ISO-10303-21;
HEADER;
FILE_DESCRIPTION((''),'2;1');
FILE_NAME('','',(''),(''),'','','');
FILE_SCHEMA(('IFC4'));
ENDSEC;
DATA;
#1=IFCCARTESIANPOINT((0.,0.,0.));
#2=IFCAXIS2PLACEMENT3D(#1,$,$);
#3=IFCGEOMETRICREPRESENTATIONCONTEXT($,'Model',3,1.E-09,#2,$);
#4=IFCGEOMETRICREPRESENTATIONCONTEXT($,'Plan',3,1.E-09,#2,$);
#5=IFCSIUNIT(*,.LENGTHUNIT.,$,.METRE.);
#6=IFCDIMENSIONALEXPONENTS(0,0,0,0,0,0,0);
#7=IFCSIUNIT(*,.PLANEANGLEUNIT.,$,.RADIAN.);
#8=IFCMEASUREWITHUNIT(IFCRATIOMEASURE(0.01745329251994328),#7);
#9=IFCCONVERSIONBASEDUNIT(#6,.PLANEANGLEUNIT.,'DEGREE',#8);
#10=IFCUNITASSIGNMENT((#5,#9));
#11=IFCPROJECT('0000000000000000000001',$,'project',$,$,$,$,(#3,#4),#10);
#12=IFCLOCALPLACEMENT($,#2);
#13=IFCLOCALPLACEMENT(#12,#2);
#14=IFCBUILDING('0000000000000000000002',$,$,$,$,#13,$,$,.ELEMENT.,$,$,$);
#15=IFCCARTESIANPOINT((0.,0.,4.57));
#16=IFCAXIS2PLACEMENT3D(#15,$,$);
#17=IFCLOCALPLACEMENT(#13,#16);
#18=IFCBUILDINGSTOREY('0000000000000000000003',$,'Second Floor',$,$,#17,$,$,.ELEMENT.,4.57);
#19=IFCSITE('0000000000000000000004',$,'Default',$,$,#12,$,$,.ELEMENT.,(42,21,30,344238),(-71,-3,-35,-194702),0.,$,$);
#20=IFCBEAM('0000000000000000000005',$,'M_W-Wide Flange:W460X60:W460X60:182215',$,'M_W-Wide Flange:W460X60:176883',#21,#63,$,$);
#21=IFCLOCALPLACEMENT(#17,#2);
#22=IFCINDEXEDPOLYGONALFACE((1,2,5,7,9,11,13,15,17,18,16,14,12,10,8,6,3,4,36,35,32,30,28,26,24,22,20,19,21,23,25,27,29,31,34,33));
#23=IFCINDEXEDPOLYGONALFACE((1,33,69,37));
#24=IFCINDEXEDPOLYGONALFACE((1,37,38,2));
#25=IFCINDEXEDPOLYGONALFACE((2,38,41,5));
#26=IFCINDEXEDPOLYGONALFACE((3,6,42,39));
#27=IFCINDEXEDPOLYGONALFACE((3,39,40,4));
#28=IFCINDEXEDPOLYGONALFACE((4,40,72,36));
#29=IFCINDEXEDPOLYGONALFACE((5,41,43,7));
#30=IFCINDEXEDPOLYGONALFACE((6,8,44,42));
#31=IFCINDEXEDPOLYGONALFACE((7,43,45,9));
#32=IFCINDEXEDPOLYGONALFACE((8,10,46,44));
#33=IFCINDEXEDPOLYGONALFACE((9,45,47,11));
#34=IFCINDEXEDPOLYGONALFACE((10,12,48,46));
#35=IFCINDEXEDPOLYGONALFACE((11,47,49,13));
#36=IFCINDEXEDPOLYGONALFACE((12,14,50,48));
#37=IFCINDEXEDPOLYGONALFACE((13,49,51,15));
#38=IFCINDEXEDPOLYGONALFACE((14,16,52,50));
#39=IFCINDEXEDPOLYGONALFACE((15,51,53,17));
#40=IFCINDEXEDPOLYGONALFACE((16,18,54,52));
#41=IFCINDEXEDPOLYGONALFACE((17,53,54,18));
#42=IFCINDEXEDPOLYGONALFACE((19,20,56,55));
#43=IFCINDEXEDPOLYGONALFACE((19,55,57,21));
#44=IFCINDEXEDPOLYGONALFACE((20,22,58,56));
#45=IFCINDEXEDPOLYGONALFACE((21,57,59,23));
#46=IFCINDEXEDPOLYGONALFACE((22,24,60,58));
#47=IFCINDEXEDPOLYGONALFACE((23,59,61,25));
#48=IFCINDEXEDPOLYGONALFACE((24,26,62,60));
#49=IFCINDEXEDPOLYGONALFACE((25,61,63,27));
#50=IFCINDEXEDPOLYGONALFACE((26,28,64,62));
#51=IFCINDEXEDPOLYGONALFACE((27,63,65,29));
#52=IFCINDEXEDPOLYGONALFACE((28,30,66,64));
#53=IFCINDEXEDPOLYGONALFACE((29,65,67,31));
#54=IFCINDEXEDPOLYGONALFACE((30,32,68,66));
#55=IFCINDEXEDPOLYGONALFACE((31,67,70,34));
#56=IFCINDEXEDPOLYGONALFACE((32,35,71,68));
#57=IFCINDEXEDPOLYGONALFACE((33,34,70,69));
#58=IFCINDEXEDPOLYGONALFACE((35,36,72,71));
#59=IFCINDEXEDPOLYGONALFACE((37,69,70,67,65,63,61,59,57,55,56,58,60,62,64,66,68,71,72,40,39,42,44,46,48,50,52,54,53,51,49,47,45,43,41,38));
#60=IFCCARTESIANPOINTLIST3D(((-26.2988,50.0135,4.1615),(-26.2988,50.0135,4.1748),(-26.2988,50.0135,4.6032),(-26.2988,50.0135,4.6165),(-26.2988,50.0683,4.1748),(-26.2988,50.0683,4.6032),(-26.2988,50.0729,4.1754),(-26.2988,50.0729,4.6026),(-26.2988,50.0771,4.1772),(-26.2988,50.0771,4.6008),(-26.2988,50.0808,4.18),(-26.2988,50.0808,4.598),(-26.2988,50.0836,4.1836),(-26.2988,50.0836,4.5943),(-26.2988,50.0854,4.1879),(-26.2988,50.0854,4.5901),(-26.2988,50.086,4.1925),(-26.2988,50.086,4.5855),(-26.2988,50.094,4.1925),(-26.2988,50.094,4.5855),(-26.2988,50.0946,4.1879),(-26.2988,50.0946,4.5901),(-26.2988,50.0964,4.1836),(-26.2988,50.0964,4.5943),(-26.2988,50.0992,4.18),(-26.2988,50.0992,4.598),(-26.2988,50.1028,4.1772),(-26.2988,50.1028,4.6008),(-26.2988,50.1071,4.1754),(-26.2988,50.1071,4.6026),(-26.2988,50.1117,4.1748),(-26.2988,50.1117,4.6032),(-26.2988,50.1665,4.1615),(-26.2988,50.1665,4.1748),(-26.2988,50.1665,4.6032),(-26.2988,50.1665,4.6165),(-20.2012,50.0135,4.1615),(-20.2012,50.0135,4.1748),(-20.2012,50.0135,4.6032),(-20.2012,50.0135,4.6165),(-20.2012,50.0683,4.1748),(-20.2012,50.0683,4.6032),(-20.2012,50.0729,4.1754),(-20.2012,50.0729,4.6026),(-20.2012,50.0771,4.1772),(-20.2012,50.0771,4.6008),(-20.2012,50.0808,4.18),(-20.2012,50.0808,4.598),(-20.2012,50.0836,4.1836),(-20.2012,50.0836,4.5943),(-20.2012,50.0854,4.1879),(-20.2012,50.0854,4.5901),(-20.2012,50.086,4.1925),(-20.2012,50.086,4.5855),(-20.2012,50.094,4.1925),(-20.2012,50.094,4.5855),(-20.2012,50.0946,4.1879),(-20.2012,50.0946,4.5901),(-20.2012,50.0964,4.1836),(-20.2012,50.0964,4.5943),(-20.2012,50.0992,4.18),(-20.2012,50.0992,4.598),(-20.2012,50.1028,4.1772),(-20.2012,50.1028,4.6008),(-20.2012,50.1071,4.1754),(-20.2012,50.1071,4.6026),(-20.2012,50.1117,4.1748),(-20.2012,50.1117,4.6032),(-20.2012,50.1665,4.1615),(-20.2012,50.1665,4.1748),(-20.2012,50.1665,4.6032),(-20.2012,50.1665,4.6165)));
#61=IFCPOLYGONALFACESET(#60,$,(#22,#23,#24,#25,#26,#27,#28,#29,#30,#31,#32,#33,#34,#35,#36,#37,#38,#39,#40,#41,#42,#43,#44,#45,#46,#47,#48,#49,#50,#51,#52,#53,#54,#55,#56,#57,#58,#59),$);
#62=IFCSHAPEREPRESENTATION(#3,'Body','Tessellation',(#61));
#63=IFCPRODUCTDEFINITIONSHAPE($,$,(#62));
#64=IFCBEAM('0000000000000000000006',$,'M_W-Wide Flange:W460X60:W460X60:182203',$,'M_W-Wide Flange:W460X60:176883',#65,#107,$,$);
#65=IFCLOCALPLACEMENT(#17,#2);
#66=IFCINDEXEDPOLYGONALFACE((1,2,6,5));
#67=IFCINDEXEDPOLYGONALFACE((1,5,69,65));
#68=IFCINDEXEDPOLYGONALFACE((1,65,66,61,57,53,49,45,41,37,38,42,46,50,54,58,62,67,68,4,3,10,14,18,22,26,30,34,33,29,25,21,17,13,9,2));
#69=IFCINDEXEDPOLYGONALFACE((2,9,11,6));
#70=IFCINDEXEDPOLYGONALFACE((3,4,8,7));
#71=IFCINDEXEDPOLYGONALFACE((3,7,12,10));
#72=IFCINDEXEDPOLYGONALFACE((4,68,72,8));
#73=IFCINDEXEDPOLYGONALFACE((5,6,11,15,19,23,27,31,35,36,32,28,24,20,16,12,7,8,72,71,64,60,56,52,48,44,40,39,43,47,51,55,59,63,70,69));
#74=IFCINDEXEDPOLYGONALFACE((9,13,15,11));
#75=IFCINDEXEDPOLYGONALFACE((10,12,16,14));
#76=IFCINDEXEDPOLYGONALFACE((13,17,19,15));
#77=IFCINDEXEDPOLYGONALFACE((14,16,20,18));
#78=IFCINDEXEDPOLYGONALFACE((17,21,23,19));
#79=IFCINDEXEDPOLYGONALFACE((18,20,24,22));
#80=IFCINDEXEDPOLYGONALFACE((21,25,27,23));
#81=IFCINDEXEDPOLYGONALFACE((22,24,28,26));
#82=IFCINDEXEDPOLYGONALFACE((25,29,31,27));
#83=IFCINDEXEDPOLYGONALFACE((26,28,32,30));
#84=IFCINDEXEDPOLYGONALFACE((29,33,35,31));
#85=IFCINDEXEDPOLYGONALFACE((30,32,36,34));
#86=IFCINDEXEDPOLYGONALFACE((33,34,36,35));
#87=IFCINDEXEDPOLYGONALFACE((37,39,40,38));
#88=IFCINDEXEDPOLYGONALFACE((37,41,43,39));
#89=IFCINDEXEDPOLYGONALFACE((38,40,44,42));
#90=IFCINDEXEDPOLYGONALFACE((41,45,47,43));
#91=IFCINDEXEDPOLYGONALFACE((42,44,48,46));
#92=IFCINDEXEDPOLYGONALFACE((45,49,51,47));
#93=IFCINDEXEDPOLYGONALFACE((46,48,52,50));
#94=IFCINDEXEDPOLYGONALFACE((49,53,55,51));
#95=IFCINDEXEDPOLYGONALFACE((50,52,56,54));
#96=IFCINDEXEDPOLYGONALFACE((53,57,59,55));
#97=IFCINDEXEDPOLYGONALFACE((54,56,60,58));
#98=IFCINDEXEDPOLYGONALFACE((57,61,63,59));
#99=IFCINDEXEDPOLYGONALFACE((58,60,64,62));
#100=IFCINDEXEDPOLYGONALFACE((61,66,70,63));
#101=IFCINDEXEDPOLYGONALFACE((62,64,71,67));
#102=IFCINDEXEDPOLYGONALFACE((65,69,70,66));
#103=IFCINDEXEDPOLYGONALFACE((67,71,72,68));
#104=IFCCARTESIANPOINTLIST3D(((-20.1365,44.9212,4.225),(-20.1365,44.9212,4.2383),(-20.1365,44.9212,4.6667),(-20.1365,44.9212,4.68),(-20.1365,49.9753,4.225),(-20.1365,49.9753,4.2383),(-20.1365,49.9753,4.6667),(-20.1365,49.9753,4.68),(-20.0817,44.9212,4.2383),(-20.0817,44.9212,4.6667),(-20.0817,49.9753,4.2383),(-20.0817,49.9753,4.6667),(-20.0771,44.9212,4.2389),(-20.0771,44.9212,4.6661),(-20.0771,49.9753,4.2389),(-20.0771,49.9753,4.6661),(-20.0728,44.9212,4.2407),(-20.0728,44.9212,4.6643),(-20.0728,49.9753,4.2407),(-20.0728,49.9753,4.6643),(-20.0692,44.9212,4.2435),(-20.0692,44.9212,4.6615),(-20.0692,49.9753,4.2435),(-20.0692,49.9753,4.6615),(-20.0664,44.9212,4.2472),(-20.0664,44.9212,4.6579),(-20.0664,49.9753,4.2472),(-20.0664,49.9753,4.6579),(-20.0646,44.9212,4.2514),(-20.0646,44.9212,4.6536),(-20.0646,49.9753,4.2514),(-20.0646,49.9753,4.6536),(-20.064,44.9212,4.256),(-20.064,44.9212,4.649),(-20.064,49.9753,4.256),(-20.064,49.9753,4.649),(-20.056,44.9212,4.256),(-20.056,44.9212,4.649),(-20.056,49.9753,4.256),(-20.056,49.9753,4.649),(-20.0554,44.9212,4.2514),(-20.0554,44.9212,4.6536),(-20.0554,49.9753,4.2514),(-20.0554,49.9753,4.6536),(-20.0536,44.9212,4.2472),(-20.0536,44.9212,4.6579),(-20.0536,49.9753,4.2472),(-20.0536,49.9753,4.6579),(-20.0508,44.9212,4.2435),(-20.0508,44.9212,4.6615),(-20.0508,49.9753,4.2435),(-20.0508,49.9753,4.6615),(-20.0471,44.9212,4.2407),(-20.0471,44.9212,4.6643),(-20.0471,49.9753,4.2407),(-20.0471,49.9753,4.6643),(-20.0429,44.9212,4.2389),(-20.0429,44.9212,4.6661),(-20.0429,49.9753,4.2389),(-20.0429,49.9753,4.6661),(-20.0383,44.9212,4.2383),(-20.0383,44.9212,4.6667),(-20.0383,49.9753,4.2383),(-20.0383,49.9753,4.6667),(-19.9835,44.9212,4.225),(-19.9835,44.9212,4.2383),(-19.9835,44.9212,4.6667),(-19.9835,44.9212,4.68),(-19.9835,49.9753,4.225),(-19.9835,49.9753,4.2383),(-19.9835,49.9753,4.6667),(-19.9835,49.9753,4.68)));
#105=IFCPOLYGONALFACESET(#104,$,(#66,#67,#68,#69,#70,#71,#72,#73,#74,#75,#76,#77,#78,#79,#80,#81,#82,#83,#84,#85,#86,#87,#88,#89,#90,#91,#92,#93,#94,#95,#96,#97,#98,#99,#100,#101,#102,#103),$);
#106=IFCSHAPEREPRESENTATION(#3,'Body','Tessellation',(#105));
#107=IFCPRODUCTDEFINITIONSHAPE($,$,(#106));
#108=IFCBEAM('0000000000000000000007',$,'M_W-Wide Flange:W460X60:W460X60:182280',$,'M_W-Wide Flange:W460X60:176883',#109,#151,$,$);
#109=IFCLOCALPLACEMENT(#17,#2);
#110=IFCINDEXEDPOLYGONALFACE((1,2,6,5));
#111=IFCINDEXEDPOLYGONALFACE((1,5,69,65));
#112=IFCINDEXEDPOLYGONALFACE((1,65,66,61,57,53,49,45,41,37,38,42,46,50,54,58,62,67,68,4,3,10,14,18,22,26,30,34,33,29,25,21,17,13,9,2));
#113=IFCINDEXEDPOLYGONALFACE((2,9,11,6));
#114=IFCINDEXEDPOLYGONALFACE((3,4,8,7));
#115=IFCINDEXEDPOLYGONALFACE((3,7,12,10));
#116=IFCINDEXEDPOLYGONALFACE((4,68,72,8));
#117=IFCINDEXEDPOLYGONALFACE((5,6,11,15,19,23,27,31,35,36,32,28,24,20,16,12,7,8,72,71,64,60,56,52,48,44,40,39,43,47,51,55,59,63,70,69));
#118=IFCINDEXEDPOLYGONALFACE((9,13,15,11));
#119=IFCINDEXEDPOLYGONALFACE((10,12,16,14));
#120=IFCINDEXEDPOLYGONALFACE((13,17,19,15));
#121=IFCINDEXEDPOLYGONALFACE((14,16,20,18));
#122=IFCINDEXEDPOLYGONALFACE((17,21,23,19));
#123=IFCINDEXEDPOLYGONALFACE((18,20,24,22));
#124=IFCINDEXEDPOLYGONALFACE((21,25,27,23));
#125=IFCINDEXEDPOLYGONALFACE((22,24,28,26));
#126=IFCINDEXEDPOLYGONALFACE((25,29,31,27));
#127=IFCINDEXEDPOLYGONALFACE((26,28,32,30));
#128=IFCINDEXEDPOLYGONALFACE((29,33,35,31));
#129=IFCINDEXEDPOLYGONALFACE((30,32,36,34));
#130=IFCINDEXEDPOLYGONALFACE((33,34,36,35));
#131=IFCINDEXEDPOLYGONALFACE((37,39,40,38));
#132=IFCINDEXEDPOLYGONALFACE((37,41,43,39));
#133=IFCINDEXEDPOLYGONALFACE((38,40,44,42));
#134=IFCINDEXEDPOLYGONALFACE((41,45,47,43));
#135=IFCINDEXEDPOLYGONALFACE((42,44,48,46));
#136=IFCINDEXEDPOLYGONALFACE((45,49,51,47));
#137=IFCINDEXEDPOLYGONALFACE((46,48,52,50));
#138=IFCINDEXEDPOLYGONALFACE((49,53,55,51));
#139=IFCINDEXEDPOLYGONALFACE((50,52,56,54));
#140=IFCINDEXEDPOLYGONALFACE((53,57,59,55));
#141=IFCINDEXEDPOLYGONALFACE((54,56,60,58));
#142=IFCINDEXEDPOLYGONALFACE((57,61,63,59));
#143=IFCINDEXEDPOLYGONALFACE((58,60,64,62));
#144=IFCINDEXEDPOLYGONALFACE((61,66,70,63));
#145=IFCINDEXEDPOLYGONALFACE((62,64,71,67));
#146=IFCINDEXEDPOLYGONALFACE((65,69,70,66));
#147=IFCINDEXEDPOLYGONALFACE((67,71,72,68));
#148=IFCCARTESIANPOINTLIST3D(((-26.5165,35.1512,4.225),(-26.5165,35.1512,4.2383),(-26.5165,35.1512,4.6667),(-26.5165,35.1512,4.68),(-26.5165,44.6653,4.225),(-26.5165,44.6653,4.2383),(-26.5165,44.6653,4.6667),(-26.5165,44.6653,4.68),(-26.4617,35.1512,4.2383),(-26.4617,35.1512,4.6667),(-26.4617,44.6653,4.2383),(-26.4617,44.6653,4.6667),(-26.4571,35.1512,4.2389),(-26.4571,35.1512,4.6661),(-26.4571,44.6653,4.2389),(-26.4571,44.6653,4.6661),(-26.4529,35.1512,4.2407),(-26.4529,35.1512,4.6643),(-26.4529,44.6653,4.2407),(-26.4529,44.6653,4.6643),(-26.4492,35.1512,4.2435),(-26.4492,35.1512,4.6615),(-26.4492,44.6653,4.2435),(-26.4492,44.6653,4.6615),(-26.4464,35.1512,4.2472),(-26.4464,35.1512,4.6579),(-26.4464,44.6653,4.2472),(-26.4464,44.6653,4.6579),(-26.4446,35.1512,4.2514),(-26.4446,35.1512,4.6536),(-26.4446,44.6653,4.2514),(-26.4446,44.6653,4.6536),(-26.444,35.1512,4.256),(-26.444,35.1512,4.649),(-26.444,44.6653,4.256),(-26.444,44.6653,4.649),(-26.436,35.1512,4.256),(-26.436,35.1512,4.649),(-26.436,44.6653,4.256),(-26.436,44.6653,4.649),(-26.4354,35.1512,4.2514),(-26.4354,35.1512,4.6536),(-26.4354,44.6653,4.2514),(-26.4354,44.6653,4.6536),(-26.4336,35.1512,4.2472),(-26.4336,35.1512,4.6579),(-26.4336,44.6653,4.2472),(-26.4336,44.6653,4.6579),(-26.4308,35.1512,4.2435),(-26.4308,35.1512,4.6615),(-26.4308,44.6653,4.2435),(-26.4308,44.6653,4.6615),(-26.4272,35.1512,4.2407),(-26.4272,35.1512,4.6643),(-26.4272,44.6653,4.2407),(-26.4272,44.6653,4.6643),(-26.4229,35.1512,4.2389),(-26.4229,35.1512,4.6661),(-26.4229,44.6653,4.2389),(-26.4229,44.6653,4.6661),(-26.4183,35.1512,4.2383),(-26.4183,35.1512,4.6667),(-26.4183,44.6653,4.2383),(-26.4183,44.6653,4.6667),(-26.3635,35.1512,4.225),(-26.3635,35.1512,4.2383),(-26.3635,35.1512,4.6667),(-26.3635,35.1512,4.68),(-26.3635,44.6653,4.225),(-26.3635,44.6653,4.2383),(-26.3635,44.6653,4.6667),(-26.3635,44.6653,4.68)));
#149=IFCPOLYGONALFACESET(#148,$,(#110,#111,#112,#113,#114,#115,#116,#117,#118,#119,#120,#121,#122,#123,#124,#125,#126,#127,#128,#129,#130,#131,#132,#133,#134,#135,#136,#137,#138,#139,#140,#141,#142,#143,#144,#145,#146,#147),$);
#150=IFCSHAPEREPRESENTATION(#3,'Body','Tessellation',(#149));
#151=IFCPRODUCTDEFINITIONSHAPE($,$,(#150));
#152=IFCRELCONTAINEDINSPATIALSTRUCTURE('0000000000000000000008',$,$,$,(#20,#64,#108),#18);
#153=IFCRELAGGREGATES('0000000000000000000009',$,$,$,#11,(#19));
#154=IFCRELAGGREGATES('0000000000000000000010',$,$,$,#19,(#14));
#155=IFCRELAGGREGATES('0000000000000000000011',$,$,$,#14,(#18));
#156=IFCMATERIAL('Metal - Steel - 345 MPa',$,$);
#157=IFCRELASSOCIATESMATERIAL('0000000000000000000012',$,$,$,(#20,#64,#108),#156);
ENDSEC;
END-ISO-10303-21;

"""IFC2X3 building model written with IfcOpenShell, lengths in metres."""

from ifc_helpers import new_model, entity, si_unit, converted_unit, frame, frame_2d, origin, place, context, project, spatial, polyline, circle_curve, parameter, trimmed, segment, composite_curve, outline, extrude, material, element, save


model = new_model("IFC2X3")

# Units and contexts
model_context = context("Model", 3, precision=1e-09, world=origin())
plan_context = context("Plan", 3, precision=1e-09, world=origin())
ifc_project = project(units=[si_unit("LENGTHUNIT", "METRE"), converted_unit("PLANEANGLEUNIT", "DEGREE", entity("IfcRatioMeasure", 0.01745329251994328), si_unit("PLANEANGLEUNIT", "RADIAN"), dimensions=[0, 0, 0, 0, 0, 0, 0])], contexts=[model_context, plan_context])

# Site, building, storey
site_placement = place(None, origin())
site = spatial("IfcSite", under=ifc_project, at=site_placement, Name="Default", CompositionType="ELEMENT", RefLatitude=(42, 21, 30, 344238), RefLongitude=(-71, -3, -35, -194702), RefElevation=0.0)
building_placement = place(site_placement, origin())
building = spatial("IfcBuilding", under=site, at=building_placement, CompositionType="ELEMENT")
storey_placement = place(building_placement, frame((0.0, 0.0, 4.57)))
storey = spatial("IfcBuildingStorey", under=building, at=storey_placement, Name="Second Floor", CompositionType="ELEMENT", Elevation=4.57)

# Shared definitions
ifc_material = material(Name="Metal - Steel - 345 MPa")

# Beams
beam_1_placement = place(storey_placement, frame((-20.063, 50.09, 4.6165), z_axis=(0.0, 0.0, 1.0), x_axis=(0.0, 1.0, 0.0)))
element("IfcBeam", 1, at=beam_1_placement, inside=storey, material=ifc_material, Name="M_W-Wide Flange:W460X60:W460X60:182215", ObjectType="M_W-Wide Flange:W460X60:176883", context=model_context, shape_type="SweptSolid", body=[
    extrude(outline(composite_curve([segment(polyline([(0.2142, -0.0765), (0.2275, -0.0765)]), True, "CONTINUOUS"), segment(polyline([(0.2275, -0.0765), (0.2275, 0.0765)]), True, "CONTINUOUS"), segment(polyline([(0.2275, 0.0765), (0.2142, 0.0765)]), True, "CONTINUOUS"), segment(polyline([(0.2142, 0.0765), (0.2142, 0.0217)]), True, "CONTINUOUS"), segment(trimmed(circle_curve(frame_2d((0.1965, 0.0217), x_axis=(1.0, 0.0)), 0.0177), [parameter(270.0)], [parameter(360.0)], True, "PARAMETER"), False, "CONTINUOUS"), segment(polyline([(0.1965, 0.004), (-0.1965, 0.004)]), True, "CONTINUOUS"), segment(trimmed(circle_curve(frame_2d((-0.1965, 0.0217), x_axis=(0.0, -1.0)), 0.0177), [parameter(270.0)], [parameter(360.0)], True, "PARAMETER"), False, "CONTINUOUS"), segment(polyline([(-0.2142, 0.0217), (-0.2142, 0.0765)]), True, "CONTINUOUS"), segment(polyline([(-0.2142, 0.0765), (-0.2275, 0.0765)]), True, "CONTINUOUS"), segment(polyline([(-0.2275, 0.0765), (-0.2275, -0.0765)]), True, "CONTINUOUS"), segment(polyline([(-0.2275, -0.0765), (-0.2142, -0.0765)]), True, "CONTINUOUS"), segment(polyline([(-0.2142, -0.0765), (-0.2142, -0.0217)]), True, "CONTINUOUS"), segment(trimmed(circle_curve(frame_2d((-0.1965, -0.0217), x_axis=(-1.0, 0.0)), 0.0177), [parameter(270.0)], [parameter(360.0)], True, "PARAMETER"), False, "CONTINUOUS"), segment(polyline([(-0.1965, -0.004), (0.1965, -0.004)]), True, "CONTINUOUS"), segment(trimmed(circle_curve(frame_2d((0.1965, -0.0217), x_axis=(0.0, 1.0)), 0.0177), [parameter(270.0)], [parameter(0.0)], True, "PARAMETER"), False, "CONTINUOUS"), segment(polyline([(0.2142, -0.0217), (0.2142, -0.0765)]), True, "CONTINUOUS")], self_intersect=False)), frame((0.0, 6.2358, -0.2275), z_axis=(0.0, -1.0, 0.0), x_axis=(0.0, 0.0, -1.0)), (0.0, 0.0, 1.0), 6.0976),
])
beam_2_placement = place(storey_placement, frame((-20.06, 44.7836, 4.68)))
element("IfcBeam", 2, at=beam_2_placement, inside=storey, material=ifc_material, Name="M_W-Wide Flange:W460X60:W460X60:182203", ObjectType="M_W-Wide Flange:W460X60:176883", context=model_context, shape_type="SweptSolid", body=[
    extrude(outline(composite_curve([segment(polyline([(-0.0765, -0.2142), (-0.0765, -0.2275)]), True, "CONTINUOUS"), segment(polyline([(-0.0765, -0.2275), (0.0765, -0.2275)]), True, "CONTINUOUS"), segment(polyline([(0.0765, -0.2275), (0.0765, -0.2142)]), True, "CONTINUOUS"), segment(polyline([(0.0765, -0.2142), (0.0217, -0.2142)]), True, "CONTINUOUS"), segment(trimmed(circle_curve(frame_2d((0.0217, -0.1965), x_axis=(1.0, 0.0)), 0.0177), [parameter(180.0)], [parameter(270.0)], True, "PARAMETER"), False, "CONTINUOUS"), segment(polyline([(0.004, -0.1965), (0.004, 0.1965)]), True, "CONTINUOUS"), segment(trimmed(circle_curve(frame_2d((0.0217, 0.1965), x_axis=(1.0, 0.0)), 0.0177), [parameter(90.0)], [parameter(180.0)], True, "PARAMETER"), False, "CONTINUOUS"), segment(polyline([(0.0217, 0.2142), (0.0765, 0.2142)]), True, "CONTINUOUS"), segment(polyline([(0.0765, 0.2142), (0.0765, 0.2275)]), True, "CONTINUOUS"), segment(polyline([(0.0765, 0.2275), (-0.0765, 0.2275)]), True, "CONTINUOUS"), segment(polyline([(-0.0765, 0.2275), (-0.0765, 0.2142)]), True, "CONTINUOUS"), segment(polyline([(-0.0765, 0.2142), (-0.0217, 0.2142)]), True, "CONTINUOUS"), segment(trimmed(circle_curve(frame_2d((-0.0217, 0.1965), x_axis=(1.0, 0.0)), 0.0177), [parameter(360.0)], [parameter(90.0)], True, "PARAMETER"), False, "CONTINUOUS"), segment(polyline([(-0.004, 0.1965), (-0.004, -0.1965)]), True, "CONTINUOUS"), segment(trimmed(circle_curve(frame_2d((-0.0217, -0.1965), x_axis=(1.0, 0.0)), 0.0177), [parameter(270.0)], [parameter(0.0)], True, "PARAMETER"), False, "CONTINUOUS"), segment(polyline([(-0.0217, -0.2142), (-0.0765, -0.2142)]), True, "CONTINUOUS")], self_intersect=False)), frame((0.0, 0.1376, -0.2275), z_axis=(0.0, -1.0, 0.0), x_axis=(1.0, 0.0, 0.0)), (0.0, 0.0, -1.0), 5.0541),
])
beam_3_placement = place(storey_placement, frame((-26.44, 44.7781, 4.68), z_axis=(0.0, 0.0, 1.0), x_axis=(-1.0, 0.0, 0.0)))
element("IfcBeam", 3, at=beam_3_placement, inside=storey, material=ifc_material, Name="M_W-Wide Flange:W460X60:W460X60:182280", ObjectType="M_W-Wide Flange:W460X60:176883", context=model_context, shape_type="SweptSolid", body=[
    extrude(outline(composite_curve([segment(polyline([(0.2142, -0.0765), (0.2275, -0.0765)]), True, "CONTINUOUS"), segment(polyline([(0.2275, -0.0765), (0.2275, 0.0765)]), True, "CONTINUOUS"), segment(polyline([(0.2275, 0.0765), (0.2142, 0.0765)]), True, "CONTINUOUS"), segment(polyline([(0.2142, 0.0765), (0.2142, 0.0217)]), True, "CONTINUOUS"), segment(trimmed(circle_curve(frame_2d((0.1965, 0.0217), x_axis=(1.0, 0.0)), 0.0177), [parameter(270.0)], [parameter(360.0)], True, "PARAMETER"), False, "CONTINUOUS"), segment(polyline([(0.1965, 0.004), (-0.1965, 0.004)]), True, "CONTINUOUS"), segment(trimmed(circle_curve(frame_2d((-0.1965, 0.0217), x_axis=(0.0, -1.0)), 0.0177), [parameter(270.0)], [parameter(360.0)], True, "PARAMETER"), False, "CONTINUOUS"), segment(polyline([(-0.2142, 0.0217), (-0.2142, 0.0765)]), True, "CONTINUOUS"), segment(polyline([(-0.2142, 0.0765), (-0.2275, 0.0765)]), True, "CONTINUOUS"), segment(polyline([(-0.2275, 0.0765), (-0.2275, -0.0765)]), True, "CONTINUOUS"), segment(polyline([(-0.2275, -0.0765), (-0.2142, -0.0765)]), True, "CONTINUOUS"), segment(polyline([(-0.2142, -0.0765), (-0.2142, -0.0217)]), True, "CONTINUOUS"), segment(trimmed(circle_curve(frame_2d((-0.1965, -0.0217), x_axis=(-1.0, 0.0)), 0.0177), [parameter(270.0)], [parameter(360.0)], True, "PARAMETER"), False, "CONTINUOUS"), segment(polyline([(-0.1965, -0.004), (0.1965, -0.004)]), True, "CONTINUOUS"), segment(trimmed(circle_curve(frame_2d((0.1965, -0.0217), x_axis=(0.0, 1.0)), 0.0177), [parameter(270.0)], [parameter(0.0)], True, "PARAMETER"), False, "CONTINUOUS"), segment(polyline([(0.2142, -0.0217), (0.2142, -0.0765)]), True, "CONTINUOUS")], self_intersect=False)), frame((0.0, 9.6269, -0.2275), z_axis=(0.0, -1.0, 0.0), x_axis=(0.0, 0.0, -1.0)), (0.0, 0.0, 1.0), 9.5141),
])

save(model, "model.ifc")
